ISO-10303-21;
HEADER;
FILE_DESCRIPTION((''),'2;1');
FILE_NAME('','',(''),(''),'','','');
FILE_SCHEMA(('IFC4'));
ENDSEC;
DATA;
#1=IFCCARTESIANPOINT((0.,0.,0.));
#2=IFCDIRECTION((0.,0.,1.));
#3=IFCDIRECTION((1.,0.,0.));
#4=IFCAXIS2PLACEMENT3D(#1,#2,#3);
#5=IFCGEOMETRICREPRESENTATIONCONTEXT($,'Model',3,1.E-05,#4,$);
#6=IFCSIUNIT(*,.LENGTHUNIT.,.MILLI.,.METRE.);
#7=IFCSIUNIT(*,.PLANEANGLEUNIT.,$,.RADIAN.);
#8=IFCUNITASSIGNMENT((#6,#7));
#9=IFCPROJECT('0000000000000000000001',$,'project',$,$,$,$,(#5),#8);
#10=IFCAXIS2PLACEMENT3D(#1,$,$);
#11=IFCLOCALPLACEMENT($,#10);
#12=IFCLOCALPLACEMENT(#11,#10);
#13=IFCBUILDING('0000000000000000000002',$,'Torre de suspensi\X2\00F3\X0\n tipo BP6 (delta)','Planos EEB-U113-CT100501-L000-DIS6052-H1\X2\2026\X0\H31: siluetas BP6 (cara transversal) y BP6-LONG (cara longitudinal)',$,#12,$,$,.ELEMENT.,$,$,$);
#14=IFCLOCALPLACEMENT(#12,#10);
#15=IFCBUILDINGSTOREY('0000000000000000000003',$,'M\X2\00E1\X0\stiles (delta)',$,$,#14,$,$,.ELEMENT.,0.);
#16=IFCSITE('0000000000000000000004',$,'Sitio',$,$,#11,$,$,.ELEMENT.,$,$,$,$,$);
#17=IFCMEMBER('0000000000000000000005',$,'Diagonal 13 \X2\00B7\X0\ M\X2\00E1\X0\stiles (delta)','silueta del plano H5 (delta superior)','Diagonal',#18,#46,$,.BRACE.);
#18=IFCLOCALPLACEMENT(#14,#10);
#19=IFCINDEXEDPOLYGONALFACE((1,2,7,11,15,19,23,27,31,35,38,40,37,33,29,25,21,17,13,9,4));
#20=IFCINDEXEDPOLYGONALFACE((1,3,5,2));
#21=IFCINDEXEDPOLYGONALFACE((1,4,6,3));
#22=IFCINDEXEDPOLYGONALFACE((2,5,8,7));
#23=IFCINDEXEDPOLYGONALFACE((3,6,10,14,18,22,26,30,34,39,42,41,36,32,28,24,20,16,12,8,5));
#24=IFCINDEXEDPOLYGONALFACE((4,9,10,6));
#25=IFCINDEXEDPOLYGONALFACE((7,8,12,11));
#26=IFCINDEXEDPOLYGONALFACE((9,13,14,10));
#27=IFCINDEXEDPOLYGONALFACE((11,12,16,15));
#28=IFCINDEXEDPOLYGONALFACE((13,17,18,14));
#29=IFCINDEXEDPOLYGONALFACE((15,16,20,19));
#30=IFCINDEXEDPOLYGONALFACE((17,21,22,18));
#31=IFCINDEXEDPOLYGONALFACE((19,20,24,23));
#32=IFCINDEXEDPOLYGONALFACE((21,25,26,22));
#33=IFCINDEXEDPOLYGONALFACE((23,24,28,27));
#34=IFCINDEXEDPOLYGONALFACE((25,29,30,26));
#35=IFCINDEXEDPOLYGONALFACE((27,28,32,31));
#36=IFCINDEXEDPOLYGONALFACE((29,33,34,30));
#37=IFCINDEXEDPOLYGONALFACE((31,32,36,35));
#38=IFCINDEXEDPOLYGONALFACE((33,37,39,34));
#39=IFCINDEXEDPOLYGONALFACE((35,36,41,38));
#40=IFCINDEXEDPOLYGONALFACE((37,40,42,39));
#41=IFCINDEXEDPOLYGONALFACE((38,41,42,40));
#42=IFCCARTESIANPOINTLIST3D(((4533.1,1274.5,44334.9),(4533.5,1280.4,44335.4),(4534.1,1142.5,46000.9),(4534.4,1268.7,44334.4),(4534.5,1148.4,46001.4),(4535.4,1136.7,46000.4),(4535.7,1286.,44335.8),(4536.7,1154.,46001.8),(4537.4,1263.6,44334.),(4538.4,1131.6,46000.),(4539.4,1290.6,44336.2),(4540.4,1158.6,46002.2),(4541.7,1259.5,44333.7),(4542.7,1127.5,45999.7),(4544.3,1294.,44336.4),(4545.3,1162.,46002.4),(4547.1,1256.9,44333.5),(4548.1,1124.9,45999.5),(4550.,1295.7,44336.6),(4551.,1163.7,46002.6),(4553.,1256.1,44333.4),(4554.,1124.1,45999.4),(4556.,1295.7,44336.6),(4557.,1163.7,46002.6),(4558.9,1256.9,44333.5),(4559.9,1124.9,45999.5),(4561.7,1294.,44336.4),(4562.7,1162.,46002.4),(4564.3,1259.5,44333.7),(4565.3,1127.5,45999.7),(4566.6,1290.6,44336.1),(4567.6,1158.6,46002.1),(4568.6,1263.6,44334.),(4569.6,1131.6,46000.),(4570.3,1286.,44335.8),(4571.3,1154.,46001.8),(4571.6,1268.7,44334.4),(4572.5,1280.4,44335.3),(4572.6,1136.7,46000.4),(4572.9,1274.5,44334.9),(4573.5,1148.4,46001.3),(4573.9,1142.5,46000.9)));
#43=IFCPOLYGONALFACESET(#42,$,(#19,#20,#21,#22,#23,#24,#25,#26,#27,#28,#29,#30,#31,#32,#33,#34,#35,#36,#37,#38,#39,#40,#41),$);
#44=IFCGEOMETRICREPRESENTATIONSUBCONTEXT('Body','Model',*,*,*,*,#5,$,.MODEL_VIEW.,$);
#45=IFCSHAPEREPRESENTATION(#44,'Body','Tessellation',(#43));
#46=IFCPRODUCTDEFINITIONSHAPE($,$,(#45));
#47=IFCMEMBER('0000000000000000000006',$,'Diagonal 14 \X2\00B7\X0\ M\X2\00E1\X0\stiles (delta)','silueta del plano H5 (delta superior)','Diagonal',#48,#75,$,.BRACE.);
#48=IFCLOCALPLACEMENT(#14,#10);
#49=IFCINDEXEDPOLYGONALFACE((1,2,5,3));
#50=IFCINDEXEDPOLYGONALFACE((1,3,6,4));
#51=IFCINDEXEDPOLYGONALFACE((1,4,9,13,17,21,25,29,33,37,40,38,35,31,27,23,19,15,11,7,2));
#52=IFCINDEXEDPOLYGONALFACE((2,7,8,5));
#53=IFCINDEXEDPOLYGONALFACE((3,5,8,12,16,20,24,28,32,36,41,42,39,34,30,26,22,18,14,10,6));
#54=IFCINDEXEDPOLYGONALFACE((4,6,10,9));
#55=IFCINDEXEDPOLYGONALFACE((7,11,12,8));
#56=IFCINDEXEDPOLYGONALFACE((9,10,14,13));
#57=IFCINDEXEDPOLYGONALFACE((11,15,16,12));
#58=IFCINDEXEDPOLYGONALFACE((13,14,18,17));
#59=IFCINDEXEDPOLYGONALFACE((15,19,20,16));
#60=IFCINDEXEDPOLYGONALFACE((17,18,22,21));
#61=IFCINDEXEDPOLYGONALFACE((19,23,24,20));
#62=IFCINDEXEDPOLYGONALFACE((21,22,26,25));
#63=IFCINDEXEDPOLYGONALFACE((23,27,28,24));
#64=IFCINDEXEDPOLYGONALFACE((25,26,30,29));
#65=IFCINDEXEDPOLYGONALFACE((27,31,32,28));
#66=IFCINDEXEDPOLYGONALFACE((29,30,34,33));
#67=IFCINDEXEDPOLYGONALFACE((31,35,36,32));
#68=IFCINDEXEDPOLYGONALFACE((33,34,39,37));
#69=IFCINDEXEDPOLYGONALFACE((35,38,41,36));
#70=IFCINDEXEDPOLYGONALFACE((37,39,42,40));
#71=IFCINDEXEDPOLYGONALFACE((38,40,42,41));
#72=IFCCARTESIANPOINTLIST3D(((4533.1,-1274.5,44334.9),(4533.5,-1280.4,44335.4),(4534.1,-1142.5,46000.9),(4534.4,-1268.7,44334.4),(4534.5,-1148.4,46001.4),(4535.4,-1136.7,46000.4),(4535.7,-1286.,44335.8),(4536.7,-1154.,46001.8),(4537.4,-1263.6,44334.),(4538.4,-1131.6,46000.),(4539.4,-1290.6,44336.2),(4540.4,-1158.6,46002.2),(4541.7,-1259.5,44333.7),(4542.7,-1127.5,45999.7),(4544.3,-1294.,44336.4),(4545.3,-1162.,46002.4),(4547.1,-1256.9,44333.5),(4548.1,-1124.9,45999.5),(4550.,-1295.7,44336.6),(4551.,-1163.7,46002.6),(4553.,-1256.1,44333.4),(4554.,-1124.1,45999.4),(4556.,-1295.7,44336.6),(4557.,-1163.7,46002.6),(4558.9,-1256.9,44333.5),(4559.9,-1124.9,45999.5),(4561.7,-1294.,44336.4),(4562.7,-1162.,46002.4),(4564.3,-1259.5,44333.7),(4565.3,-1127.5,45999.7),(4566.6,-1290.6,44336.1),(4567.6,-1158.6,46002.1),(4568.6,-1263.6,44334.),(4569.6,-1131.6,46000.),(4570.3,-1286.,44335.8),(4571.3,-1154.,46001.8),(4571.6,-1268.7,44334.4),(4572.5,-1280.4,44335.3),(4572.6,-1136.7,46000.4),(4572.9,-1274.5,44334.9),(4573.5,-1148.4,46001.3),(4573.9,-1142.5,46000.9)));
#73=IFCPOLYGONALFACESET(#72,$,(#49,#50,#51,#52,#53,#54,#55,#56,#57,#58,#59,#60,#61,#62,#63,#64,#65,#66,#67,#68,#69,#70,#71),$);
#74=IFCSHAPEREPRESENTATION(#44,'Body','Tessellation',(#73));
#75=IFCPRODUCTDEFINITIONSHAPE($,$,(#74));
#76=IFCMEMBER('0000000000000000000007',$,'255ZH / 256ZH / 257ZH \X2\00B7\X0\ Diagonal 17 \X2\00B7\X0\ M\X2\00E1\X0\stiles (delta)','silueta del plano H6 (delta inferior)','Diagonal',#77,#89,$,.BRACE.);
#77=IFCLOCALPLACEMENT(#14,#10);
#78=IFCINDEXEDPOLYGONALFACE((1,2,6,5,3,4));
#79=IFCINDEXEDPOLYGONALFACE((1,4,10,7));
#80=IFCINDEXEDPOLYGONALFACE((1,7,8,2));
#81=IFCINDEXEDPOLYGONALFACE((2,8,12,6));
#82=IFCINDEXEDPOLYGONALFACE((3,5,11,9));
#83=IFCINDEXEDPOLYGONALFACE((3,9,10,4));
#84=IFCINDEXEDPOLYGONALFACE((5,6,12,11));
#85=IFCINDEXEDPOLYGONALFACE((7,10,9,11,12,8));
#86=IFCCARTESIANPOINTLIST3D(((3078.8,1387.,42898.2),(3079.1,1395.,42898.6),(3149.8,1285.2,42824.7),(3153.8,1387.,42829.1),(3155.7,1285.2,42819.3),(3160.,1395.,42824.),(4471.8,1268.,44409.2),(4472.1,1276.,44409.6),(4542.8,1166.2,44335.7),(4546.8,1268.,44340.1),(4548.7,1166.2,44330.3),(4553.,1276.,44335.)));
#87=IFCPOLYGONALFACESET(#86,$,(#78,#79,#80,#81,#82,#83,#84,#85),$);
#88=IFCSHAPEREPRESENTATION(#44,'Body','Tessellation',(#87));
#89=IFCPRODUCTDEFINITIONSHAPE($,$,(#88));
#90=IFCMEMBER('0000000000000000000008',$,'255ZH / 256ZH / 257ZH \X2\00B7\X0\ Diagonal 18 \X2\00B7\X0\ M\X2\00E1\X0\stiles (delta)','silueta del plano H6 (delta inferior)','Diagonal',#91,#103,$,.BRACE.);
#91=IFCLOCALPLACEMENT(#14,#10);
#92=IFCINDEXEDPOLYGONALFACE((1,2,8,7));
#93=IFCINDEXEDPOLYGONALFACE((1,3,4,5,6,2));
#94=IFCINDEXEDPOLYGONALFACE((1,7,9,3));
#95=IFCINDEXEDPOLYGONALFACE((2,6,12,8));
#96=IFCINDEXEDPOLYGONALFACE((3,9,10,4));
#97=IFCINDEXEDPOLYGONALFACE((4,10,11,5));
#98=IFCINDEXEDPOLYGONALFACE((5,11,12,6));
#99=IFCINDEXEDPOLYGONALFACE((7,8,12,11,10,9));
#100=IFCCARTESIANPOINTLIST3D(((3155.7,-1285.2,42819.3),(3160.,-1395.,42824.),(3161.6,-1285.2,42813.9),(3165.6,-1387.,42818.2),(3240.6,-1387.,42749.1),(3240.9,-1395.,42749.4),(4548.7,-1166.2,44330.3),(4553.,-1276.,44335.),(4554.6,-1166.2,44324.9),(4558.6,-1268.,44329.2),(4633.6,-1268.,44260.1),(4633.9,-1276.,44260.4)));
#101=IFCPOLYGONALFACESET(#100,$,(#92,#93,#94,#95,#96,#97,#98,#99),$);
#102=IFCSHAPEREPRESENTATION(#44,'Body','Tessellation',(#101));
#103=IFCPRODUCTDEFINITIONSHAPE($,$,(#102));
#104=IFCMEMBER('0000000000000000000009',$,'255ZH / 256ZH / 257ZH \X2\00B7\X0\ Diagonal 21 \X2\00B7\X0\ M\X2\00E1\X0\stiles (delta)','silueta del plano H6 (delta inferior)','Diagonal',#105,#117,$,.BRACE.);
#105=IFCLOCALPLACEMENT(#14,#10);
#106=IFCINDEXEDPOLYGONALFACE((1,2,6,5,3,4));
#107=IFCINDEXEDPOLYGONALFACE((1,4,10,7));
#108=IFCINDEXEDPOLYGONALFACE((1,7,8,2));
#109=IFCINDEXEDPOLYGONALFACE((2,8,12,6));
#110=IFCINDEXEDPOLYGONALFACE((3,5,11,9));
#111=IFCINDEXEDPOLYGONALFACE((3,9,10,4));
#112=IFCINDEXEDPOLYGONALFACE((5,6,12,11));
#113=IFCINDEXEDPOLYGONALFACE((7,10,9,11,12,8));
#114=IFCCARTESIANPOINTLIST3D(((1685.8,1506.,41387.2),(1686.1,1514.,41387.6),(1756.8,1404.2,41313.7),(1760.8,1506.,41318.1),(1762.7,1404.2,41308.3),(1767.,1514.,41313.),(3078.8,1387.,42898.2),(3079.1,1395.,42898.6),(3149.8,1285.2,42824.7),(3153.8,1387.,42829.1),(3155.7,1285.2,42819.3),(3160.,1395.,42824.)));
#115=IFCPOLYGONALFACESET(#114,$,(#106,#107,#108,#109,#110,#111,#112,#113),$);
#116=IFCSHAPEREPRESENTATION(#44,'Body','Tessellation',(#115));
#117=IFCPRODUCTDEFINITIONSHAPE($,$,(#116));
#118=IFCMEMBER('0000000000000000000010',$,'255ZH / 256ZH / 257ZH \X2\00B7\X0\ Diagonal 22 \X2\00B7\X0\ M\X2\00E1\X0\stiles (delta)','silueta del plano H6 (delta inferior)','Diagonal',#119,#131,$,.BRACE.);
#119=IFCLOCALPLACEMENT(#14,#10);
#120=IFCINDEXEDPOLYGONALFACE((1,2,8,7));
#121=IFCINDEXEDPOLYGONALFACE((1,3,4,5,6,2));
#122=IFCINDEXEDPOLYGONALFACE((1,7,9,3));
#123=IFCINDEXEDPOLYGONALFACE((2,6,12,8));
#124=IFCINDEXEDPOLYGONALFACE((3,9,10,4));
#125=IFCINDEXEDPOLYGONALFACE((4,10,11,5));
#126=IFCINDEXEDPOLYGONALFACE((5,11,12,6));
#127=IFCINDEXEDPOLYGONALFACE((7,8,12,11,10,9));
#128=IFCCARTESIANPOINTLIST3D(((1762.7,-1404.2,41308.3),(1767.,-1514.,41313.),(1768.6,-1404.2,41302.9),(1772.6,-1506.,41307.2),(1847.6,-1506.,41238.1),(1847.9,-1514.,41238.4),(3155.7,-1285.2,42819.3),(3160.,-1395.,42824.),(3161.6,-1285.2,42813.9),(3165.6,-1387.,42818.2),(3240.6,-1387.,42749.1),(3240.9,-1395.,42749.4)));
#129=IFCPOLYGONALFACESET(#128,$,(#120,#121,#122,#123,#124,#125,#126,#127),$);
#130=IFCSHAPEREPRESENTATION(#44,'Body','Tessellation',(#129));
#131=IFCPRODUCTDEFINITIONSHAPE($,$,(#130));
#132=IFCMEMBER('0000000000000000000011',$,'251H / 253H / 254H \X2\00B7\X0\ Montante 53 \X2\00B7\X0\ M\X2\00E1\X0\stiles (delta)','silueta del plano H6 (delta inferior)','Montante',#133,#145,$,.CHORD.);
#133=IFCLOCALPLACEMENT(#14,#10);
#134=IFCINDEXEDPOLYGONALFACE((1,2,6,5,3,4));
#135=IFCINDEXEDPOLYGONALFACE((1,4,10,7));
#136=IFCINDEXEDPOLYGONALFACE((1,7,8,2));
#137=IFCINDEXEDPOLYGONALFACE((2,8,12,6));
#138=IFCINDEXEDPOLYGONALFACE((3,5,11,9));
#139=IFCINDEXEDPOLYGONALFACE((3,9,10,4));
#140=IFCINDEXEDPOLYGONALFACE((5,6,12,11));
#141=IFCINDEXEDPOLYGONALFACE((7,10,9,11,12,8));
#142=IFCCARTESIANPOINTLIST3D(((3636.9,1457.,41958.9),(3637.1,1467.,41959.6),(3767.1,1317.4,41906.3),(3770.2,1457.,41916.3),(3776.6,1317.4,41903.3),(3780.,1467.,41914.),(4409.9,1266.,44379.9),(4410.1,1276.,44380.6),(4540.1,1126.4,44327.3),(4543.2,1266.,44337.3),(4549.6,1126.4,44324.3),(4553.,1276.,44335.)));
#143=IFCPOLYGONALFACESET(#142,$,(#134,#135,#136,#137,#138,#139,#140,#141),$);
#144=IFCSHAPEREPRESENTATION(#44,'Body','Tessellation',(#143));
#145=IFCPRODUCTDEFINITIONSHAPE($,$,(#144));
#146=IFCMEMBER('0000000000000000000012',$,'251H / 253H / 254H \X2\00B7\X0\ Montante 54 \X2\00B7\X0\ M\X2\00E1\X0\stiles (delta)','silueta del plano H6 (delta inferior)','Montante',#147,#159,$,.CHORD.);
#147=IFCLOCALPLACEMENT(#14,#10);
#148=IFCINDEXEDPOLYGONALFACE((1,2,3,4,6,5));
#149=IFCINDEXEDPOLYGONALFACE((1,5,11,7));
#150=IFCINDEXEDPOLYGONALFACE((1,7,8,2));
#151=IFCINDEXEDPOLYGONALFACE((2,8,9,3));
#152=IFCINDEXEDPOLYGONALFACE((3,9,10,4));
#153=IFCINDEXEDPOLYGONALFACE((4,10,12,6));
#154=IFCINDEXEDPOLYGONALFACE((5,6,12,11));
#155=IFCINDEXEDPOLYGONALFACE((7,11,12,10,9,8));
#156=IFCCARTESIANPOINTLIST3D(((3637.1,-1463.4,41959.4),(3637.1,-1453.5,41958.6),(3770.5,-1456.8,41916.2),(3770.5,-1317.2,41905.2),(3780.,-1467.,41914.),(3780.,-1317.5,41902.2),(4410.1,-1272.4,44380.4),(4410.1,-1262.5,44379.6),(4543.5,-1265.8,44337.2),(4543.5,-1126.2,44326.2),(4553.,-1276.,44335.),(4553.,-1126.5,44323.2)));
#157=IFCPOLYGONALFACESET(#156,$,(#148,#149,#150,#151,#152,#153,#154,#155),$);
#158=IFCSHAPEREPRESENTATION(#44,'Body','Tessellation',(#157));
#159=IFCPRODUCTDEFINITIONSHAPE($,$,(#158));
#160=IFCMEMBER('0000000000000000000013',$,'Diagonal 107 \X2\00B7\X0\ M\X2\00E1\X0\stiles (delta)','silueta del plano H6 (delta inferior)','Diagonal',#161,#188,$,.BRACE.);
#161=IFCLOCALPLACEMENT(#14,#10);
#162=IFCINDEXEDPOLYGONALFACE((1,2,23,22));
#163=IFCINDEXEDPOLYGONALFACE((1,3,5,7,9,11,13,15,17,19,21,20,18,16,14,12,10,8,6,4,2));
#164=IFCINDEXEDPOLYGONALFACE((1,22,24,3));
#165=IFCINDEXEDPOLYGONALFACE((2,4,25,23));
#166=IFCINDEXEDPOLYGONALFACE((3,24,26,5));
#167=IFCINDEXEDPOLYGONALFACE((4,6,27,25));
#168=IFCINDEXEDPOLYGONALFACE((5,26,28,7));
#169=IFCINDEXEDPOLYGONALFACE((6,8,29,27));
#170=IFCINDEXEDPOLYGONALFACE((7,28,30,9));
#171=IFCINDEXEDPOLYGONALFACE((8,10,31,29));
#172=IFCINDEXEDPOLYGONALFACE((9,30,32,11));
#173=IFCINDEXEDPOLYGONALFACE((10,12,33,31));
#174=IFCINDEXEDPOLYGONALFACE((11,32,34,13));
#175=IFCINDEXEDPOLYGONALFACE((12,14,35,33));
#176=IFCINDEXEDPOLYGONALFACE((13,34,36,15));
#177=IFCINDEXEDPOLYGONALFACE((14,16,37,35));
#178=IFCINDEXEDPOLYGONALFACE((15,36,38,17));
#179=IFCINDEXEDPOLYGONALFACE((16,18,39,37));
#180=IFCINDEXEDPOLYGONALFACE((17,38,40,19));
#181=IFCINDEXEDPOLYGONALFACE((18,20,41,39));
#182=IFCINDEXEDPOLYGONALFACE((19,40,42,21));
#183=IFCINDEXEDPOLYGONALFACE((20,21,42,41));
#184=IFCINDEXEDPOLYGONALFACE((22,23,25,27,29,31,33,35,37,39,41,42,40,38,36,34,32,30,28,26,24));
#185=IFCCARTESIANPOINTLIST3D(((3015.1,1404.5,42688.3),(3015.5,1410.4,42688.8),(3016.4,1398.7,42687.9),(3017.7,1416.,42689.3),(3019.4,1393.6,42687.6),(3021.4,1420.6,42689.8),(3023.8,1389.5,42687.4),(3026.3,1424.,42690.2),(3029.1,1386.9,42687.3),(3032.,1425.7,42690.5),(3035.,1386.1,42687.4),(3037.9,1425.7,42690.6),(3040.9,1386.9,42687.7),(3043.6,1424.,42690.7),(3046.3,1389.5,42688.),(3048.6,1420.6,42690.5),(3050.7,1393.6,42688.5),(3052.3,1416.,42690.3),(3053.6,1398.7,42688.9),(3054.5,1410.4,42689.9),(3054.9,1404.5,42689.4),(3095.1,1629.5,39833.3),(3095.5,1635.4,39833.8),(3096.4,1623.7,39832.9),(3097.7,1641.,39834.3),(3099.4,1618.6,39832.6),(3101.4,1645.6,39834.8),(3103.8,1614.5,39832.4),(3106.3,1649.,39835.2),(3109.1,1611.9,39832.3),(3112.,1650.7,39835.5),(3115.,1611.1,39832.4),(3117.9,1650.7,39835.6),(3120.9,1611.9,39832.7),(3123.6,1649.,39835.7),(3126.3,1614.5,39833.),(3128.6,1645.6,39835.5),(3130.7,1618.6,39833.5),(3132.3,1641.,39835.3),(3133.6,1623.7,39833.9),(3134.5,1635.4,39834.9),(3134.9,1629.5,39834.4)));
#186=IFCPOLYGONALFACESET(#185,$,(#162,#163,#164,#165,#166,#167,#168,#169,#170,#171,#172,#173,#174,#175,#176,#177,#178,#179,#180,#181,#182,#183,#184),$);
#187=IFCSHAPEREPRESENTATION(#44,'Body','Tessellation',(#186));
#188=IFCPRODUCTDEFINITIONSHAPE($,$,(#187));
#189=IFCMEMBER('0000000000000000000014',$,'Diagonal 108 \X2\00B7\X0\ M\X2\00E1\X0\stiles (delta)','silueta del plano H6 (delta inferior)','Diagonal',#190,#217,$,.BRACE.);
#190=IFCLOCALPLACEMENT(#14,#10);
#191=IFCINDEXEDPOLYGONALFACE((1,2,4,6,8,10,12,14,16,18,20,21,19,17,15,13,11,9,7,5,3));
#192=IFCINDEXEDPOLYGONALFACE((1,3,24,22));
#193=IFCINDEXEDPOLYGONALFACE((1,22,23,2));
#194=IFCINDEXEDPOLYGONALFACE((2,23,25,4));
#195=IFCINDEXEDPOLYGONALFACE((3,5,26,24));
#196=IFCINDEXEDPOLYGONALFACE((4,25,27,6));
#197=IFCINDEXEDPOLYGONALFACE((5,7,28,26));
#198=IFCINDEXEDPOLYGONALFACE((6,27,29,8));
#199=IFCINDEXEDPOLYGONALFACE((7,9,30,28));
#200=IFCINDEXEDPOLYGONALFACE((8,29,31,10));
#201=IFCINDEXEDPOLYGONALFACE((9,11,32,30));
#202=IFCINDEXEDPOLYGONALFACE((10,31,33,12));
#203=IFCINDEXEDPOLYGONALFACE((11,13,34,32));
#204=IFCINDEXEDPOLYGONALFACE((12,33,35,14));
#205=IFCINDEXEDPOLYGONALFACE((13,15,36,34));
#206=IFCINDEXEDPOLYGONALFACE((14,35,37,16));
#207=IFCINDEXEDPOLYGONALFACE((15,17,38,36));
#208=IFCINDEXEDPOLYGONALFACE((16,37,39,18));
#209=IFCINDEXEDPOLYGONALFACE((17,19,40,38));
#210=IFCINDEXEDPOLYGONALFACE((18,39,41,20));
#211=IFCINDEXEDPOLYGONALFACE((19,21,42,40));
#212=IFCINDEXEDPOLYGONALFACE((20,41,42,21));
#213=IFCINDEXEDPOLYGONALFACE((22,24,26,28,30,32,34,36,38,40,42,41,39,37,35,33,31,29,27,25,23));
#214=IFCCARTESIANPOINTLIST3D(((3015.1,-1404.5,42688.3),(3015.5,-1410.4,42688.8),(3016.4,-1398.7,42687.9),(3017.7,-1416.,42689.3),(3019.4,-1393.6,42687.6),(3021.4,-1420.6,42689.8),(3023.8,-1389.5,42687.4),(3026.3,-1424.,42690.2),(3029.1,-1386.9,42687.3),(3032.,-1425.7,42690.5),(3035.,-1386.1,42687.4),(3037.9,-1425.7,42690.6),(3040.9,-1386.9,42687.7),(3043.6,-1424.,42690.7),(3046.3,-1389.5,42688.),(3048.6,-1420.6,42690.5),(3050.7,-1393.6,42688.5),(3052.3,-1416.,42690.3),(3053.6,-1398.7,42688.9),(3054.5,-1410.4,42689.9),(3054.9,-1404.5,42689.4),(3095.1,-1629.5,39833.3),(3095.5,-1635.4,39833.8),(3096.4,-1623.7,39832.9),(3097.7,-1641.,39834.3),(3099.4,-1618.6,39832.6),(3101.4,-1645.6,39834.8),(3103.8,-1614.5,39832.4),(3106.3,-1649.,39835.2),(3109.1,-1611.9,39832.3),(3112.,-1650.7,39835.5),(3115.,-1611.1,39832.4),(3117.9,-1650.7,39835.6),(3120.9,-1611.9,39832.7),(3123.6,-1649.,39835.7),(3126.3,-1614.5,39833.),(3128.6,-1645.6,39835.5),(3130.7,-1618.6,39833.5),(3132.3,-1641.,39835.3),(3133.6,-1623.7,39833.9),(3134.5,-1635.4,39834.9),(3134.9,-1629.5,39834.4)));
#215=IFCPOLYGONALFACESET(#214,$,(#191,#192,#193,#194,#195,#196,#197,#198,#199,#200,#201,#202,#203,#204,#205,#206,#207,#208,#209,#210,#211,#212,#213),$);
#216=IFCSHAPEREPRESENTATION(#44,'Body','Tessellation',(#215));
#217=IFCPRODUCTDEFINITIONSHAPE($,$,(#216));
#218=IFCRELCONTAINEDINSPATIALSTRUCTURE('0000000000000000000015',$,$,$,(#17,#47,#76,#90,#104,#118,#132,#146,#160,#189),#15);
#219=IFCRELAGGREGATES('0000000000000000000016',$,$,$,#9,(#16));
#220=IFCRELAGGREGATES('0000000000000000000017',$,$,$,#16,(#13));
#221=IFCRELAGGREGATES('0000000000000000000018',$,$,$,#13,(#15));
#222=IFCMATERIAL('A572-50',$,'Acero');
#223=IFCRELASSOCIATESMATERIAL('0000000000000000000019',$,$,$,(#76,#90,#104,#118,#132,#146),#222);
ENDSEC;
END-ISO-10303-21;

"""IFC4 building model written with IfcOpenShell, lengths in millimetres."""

from ifc_helpers import new_model, si_unit, frame, frame_2d, origin, origin_with_axes, place, context, subcontext, project, spatial, circle, l_section, extrude, material, element, save


model = new_model("IFC4")

# Units and contexts
model_context = context("Model", 3, precision=1e-05, world=origin_with_axes())
body_context = subcontext(model_context, "Body", "Model", "MODEL_VIEW")
ifc_project = project(units=[si_unit("LENGTHUNIT", "METRE", prefix="MILLI"), si_unit("PLANEANGLEUNIT", "RADIAN")], contexts=[model_context])

# Site, building, storey
site_placement = place(None, origin())
site = spatial("IfcSite", under=ifc_project, at=site_placement, Name="Sitio", CompositionType="ELEMENT")
building_placement = place(site_placement, origin())
building = spatial("IfcBuilding", under=site, at=building_placement, Name="Torre de suspensión tipo BP6 (delta)", Description="Planos EEB-U113-CT100501-L000-DIS6052-H1…H31: siluetas BP6 (cara transversal) y BP6-LONG (cara longitudinal)", CompositionType="ELEMENT")
storey_placement = place(building_placement, origin())
storey = spatial("IfcBuildingStorey", under=building, at=storey_placement, Name="Mástiles (delta)", CompositionType="ELEMENT", Elevation=0.0)

# Members
for number, where, z_axis, x_axis, name in (
    (1, (4554.0, 1144.0, 46001.0), (-0.000598, 0.078984, -0.996876), (-0.000047, -0.996876, -0.078984), "Diagonal 13 · Mástiles (delta)"),
    (2, (4554.0, -1144.0, 46001.0), (-0.000598, -0.078984, -0.996876), (-0.000047, 0.996876, -0.078984), "Diagonal 14 · Mástiles (delta)"),
):
    element("IfcMember", number, at=place(storey_placement, frame(where, z_axis=z_axis, x_axis=x_axis)), inside=storey, Name=name, Description="silueta del plano H5 (delta superior)", ObjectType="Diagonal", PredefinedType="BRACE", context=body_context, shape_type="SweptSolid", body=[
        extrude(circle(Radius=20.0), None, (0.0, 0.0, 1.0), 1671.2),
    ])
ifc_material = material(Name="A572-50", Category="Acero")
for number, where, z_axis, x_axis, name in (
    (3, (4553.0, 1276.0, 44335.0), (-0.676682, 0.057807, -0.734003), (-0.039182, -0.998328, -0.042502), "255ZH / 256ZH / 257ZH · Diagonal 17 · Mástiles (delta)"),
    (4, (4553.0, -1276.0, 44335.0), (-0.676682, -0.057807, -0.734003), (-0.039182, 0.998328, -0.042502), "255ZH / 256ZH / 257ZH · Diagonal 18 · Mástiles (delta)"),
    (5, (3160.0, 1395.0, 42824.0), (-0.676682, 0.057807, -0.734003), (-0.039182, -0.998328, -0.042502), "255ZH / 256ZH / 257ZH · Diagonal 21 · Mástiles (delta)"),
    (6, (3160.0, -1395.0, 42824.0), (-0.676682, -0.057807, -0.734003), (-0.039182, 0.998328, -0.042502), "255ZH / 256ZH / 257ZH · Diagonal 22 · Mástiles (delta)"),
):
    element("IfcMember", number, at=place(storey_placement, frame(where, z_axis=z_axis, x_axis=x_axis)), inside=storey, material=ifc_material, Name=name, Description="silueta del plano H6 (delta inferior)", ObjectType="Diagonal", PredefinedType="BRACE", context=body_context, shape_type="SweptSolid", body=[
        extrude(l_section(Depth=110.0, Width=110.0, Thickness=8.0, at=frame_2d((55.0, 55.0))), None, (0.0, 0.0, 1.0), 2058.6),
    ])
for number, where, z_axis, x_axis, name in (
    (7, (4553.0, 1276.0, 44335.0), (-0.303306, 0.074944, -0.949941), (-0.022795, -0.997188, -0.071393), "251H / 253H / 254H · Montante 53 · Mástiles (delta)"),
    (8, (4553.0, -1276.0, 44335.0), (-0.303306, -0.074944, -0.949941), (-0.952893, 0.023855, 0.302367), "251H / 253H / 254H · Montante 54 · Mástiles (delta)"),
):
    element("IfcMember", number, at=place(storey_placement, frame(where, z_axis=z_axis, x_axis=x_axis)), inside=storey, material=ifc_material, Name=name, Description="silueta del plano H6 (delta inferior)", ObjectType="Montante", PredefinedType="CHORD", context=body_context, shape_type="SweptSolid", body=[
        extrude(l_section(Depth=150.0, Width=150.0, Thickness=10.0, at=frame_2d((75.0, 75.0))), None, (0.0, 0.0, 1.0), 2548.6),
    ])
for number, where, z_axis, x_axis, name in (
    (9, (3035.0, 1406.0, 42689.0), (0.027924, 0.078535, -0.99652), (0.0022, -0.996911, -0.078504), "Diagonal 107 · Mástiles (delta)"),
    (10, (3035.0, -1406.0, 42689.0), (0.027924, -0.078535, -0.99652), (0.0022, 0.996911, -0.078504), "Diagonal 108 · Mástiles (delta)"),
):
    element("IfcMember", number, at=place(storey_placement, frame(where, z_axis=z_axis, x_axis=x_axis)), inside=storey, Name=name, Description="silueta del plano H6 (delta inferior)", ObjectType="Diagonal", PredefinedType="BRACE", context=body_context, shape_type="SweptSolid", body=[
        extrude(circle(Radius=20.0), None, (0.0, 0.0, 1.0), 2865.0),
    ])

save(model, "model.ifc")
